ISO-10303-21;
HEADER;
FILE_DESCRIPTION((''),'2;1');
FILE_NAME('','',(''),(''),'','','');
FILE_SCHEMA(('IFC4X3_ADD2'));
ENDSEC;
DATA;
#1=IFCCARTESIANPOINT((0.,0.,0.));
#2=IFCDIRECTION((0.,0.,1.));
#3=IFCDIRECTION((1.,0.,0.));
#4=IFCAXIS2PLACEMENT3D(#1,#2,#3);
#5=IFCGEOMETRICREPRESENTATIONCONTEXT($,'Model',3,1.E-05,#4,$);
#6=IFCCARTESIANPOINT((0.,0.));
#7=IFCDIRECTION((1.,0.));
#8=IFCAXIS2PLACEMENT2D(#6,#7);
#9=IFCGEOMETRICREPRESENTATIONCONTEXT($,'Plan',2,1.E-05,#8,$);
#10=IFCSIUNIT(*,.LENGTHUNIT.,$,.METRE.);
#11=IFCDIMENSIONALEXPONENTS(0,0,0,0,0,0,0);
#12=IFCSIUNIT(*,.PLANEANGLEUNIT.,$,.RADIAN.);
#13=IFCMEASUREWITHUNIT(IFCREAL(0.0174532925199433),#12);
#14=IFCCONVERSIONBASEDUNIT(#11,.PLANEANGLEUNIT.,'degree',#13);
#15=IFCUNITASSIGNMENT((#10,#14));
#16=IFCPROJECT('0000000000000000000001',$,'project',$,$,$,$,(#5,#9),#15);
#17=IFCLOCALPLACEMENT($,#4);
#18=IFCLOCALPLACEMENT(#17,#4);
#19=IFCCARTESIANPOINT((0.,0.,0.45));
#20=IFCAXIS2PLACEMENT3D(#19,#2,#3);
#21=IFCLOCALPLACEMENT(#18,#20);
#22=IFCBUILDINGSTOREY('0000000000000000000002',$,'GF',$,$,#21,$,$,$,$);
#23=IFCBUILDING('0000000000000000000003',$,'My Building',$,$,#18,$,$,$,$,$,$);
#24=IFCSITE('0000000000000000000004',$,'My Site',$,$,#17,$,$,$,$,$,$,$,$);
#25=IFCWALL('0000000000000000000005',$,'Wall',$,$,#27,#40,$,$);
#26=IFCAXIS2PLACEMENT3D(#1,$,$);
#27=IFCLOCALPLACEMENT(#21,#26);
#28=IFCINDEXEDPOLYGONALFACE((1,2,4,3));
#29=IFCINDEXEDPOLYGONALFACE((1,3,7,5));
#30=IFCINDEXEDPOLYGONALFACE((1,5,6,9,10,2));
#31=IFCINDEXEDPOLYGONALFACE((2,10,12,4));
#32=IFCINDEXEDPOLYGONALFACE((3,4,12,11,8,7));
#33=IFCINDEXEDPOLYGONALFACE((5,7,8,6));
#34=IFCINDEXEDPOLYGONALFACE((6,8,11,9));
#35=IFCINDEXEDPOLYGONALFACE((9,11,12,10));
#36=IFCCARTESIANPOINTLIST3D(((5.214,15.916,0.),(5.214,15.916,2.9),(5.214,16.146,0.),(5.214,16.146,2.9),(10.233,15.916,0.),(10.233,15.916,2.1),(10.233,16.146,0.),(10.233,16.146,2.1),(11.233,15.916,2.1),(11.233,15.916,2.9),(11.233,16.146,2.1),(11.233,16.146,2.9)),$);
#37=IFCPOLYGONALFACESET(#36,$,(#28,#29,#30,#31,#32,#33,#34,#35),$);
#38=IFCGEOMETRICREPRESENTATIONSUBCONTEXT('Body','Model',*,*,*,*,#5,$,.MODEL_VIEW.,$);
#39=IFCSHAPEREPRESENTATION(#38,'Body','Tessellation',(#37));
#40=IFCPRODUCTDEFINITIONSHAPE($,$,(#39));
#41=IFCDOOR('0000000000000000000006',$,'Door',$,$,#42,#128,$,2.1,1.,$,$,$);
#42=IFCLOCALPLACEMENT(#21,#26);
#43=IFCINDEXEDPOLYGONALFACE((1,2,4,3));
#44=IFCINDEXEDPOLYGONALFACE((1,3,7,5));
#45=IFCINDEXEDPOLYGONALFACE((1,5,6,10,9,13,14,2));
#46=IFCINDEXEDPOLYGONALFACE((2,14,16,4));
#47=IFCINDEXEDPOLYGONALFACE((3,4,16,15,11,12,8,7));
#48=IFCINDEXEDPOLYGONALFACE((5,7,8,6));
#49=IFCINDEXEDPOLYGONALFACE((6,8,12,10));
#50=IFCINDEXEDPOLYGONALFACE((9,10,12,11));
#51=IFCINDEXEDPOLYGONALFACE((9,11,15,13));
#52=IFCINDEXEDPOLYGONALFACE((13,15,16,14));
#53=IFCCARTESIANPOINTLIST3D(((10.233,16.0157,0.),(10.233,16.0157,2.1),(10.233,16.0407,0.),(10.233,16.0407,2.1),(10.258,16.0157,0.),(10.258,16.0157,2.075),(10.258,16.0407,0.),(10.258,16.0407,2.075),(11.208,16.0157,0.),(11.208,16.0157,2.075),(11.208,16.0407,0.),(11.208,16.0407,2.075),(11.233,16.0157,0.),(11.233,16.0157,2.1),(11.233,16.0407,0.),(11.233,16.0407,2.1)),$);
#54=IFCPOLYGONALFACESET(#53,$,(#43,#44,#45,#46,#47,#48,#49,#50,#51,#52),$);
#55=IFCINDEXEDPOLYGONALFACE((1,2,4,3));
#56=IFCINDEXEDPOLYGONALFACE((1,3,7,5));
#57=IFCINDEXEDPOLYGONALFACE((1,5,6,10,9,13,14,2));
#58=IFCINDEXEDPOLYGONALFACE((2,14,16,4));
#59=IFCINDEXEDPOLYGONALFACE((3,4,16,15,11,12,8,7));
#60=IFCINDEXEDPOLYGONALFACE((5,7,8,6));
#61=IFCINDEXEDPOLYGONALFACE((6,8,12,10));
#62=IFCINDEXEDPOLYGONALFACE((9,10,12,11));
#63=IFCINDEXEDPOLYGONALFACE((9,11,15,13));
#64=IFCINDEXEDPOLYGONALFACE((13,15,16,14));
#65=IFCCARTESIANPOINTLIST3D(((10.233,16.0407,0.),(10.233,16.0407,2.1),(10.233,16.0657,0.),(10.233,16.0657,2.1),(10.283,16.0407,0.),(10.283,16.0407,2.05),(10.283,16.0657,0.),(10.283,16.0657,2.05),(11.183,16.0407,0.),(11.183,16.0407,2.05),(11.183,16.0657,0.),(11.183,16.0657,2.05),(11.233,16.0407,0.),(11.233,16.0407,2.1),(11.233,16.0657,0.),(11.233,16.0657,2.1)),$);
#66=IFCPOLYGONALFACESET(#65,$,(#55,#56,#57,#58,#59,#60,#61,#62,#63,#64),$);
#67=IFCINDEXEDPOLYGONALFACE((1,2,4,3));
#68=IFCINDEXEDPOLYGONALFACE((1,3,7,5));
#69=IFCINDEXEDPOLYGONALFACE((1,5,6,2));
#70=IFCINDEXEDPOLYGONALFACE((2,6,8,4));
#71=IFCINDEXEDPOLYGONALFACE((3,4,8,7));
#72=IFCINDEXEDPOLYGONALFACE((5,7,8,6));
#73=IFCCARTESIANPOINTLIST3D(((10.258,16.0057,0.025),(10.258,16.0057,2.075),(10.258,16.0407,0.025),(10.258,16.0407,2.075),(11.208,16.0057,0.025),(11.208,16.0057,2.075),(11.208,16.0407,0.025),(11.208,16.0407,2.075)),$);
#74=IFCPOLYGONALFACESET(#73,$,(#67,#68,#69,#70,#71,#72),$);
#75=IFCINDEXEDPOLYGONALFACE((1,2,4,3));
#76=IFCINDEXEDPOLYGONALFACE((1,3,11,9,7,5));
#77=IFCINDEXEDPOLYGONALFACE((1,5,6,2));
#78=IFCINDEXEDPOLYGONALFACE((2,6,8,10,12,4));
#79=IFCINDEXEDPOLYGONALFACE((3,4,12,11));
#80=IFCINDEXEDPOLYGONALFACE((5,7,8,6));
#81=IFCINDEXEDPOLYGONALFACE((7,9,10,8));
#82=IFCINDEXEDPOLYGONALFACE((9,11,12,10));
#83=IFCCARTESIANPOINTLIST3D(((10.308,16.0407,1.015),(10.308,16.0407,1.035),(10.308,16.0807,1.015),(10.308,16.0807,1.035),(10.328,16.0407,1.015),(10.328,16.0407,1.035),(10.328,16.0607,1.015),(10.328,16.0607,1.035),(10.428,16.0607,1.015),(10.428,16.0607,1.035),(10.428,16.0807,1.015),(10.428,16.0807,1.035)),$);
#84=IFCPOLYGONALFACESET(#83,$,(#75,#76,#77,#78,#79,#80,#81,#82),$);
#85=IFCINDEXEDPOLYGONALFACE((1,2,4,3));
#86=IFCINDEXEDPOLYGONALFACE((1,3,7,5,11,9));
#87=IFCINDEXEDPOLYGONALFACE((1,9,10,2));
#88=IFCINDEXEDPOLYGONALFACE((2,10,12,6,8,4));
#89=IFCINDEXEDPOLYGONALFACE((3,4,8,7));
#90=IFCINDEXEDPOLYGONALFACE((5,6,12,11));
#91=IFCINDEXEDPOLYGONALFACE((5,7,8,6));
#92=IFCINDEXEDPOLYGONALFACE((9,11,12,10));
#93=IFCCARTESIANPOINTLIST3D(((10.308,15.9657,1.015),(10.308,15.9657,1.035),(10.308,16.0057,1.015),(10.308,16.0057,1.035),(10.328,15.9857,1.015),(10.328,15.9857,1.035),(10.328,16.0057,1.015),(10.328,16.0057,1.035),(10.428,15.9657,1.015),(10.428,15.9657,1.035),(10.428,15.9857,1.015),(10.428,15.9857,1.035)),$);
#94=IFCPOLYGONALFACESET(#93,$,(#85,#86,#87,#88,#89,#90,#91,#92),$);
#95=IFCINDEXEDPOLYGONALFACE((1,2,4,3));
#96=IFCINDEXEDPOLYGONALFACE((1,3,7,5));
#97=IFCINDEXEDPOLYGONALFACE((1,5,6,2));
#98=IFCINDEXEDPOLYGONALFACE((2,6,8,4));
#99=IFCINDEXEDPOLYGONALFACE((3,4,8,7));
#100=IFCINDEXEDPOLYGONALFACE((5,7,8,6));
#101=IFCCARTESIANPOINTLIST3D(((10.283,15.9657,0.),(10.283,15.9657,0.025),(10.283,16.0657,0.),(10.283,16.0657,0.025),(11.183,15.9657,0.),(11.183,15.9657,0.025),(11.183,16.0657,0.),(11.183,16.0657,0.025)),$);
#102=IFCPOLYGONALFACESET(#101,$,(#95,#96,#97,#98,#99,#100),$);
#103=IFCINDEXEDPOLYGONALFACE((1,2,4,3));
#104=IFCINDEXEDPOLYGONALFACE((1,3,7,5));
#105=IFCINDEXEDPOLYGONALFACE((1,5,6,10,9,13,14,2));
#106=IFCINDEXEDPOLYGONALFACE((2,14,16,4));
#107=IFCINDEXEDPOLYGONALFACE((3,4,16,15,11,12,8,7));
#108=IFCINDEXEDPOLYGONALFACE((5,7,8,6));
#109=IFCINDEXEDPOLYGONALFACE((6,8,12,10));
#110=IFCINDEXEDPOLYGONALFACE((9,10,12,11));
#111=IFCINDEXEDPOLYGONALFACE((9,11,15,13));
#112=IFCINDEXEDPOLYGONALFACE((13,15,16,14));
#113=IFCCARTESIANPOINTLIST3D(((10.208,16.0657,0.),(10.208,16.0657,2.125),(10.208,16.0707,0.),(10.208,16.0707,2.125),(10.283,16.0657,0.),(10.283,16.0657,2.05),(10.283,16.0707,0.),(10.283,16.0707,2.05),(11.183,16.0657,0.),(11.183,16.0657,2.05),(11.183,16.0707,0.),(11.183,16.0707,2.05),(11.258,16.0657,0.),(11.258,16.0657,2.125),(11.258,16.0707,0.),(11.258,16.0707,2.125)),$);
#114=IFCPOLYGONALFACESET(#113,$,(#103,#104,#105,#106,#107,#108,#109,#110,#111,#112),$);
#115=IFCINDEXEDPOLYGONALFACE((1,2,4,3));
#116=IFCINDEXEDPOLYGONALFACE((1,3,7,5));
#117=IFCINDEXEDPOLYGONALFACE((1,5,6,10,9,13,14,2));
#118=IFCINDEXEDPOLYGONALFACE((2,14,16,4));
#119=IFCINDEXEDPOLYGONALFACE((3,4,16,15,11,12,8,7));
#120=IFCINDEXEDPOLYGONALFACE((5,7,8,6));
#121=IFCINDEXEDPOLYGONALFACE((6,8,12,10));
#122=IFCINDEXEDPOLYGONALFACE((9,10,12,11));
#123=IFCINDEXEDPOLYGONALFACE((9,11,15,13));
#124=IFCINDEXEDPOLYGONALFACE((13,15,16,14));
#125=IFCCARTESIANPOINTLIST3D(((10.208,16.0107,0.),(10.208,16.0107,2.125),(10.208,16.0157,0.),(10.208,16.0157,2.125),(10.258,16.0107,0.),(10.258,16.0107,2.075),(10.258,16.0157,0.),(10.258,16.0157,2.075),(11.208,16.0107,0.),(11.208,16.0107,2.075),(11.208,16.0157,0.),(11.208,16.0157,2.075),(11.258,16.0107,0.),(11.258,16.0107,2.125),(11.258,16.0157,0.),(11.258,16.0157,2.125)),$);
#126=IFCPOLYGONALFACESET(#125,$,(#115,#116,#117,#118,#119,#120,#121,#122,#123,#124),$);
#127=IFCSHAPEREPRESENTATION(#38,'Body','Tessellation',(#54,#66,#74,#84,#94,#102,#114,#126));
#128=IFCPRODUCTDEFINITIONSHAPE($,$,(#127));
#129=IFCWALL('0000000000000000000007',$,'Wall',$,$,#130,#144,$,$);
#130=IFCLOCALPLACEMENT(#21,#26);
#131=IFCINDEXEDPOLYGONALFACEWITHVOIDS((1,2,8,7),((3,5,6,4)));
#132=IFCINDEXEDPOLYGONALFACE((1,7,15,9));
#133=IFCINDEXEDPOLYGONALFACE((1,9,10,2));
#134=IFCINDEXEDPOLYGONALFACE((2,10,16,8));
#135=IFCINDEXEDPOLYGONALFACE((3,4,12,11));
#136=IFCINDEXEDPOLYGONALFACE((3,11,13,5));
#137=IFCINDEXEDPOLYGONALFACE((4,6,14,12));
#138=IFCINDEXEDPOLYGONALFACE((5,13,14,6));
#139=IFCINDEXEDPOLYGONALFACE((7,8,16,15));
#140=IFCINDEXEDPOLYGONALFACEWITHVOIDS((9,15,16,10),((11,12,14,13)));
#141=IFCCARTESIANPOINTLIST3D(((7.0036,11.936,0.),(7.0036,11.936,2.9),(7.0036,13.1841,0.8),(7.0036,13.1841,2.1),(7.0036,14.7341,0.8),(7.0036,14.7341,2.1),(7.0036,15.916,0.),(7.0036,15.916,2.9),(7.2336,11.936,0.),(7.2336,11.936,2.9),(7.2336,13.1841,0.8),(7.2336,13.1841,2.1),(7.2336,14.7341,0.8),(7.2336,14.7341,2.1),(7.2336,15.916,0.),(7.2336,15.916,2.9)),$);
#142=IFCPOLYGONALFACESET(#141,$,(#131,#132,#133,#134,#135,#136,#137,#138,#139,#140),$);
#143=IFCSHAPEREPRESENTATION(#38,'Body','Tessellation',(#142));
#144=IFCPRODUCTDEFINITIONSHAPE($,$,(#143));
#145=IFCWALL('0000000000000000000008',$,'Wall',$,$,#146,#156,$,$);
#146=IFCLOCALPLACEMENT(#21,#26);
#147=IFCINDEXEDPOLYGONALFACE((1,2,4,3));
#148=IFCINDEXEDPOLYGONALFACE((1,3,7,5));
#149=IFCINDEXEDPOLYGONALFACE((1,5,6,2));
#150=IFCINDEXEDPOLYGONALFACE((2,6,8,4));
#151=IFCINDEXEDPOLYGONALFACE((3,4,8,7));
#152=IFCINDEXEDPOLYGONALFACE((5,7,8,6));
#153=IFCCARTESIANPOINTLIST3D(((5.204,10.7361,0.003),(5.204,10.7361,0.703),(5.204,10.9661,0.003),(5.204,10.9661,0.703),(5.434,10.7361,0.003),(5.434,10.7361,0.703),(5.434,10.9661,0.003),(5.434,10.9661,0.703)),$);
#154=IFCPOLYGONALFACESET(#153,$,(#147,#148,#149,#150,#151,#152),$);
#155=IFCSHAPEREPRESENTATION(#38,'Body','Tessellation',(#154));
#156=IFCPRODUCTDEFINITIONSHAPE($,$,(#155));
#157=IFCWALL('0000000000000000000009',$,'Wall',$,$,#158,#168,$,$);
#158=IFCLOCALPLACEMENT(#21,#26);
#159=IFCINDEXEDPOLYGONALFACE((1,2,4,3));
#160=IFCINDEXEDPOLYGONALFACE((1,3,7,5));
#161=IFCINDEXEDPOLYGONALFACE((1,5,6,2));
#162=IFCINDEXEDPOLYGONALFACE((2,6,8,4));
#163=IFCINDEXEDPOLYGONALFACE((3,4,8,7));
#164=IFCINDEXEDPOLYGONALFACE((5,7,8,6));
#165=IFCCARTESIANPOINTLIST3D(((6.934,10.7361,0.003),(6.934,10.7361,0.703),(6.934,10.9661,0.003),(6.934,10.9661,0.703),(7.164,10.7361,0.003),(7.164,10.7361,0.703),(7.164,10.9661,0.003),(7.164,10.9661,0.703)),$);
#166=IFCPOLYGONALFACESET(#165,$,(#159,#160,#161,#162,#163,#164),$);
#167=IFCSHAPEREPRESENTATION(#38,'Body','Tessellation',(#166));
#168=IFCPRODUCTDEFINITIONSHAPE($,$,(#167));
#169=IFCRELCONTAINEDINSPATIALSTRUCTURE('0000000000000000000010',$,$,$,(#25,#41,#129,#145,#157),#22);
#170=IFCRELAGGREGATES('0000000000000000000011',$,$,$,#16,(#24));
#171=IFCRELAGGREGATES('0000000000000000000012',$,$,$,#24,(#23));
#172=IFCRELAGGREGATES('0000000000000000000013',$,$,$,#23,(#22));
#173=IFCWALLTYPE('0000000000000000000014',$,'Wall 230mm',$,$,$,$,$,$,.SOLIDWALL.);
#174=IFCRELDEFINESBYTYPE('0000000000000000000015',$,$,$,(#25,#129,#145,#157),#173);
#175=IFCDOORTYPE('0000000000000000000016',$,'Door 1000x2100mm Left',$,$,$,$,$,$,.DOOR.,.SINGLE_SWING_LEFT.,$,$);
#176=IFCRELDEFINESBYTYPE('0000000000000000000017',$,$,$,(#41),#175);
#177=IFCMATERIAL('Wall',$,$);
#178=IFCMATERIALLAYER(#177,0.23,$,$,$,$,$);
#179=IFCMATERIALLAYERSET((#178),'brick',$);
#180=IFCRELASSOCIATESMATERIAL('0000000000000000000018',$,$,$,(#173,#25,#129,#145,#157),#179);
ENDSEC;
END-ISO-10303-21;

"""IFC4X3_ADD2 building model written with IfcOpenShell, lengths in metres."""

from ifc_helpers import new_model, entity, si_unit, converted_unit, frame, origin_with_axes, origin_2d_with_axis, place, context, subcontext, project, spatial, line, indexed_curve, outline, extrude, shape, source, transform, mapped, material, layer, layer_set, layer_usage, type_object, type_shapes, element, fill, save


model = new_model("IFC4X3_ADD2")

# Units and contexts
model_context = context("Model", 3, precision=1e-05, world=origin_with_axes())
plan_context = context("Plan", 2, precision=1e-05, world=origin_2d_with_axis())
body_context_1 = subcontext(model_context, "Body", "Model", "MODEL_VIEW")
body_context_2 = subcontext(plan_context, "Body", "Plan", "PLAN_VIEW")
ifc_project = project(units=[si_unit("LENGTHUNIT", "METRE"), converted_unit("PLANEANGLEUNIT", "degree", entity("IfcReal", 0.0174532925199433), si_unit("PLANEANGLEUNIT", "RADIAN"), dimensions=[0, 0, 0, 0, 0, 0, 0])], contexts=[model_context, plan_context])

# Site, building, storey
site_placement = place(None, origin_with_axes())
site = spatial("IfcSite", under=ifc_project, at=site_placement, Name="My Site")
building_placement = place(site_placement, origin_with_axes())
building = spatial("IfcBuilding", under=site, at=building_placement, Name="My Building")
storey_placement = place(building_placement, frame((0.0, 0.0, 0.45), z_axis=(0.0, 0.0, 1.0), x_axis=(1.0, 0.0, 0.0)))
storey = spatial("IfcBuildingStorey", under=building, at=storey_placement, Name="GF")

# Shared definitions
ifc_material_1 = material(Name="Wall")
ifc_layer_1 = layer(ifc_material_1, 0.23)
ifc_layer_set_1 = layer_set([ifc_layer_1], Name="brick")
wall_type_1 = type_object("IfcWallType", Name="Wall 230mm", PredefinedType="SOLIDWALL", material=ifc_layer_set_1)
shared_shape_1 = source(origin_with_axes(), body_context_1, "Body", "SweptSolid", [
    extrude(outline(indexed_curve([(0.0, 0.0), (1.55, 0.0), (1.55, 1.3), (0.0, 1.3)], segments=[line(1, 2, 3, 4, 1)])), frame((-0.775, -0.6, 0.0), z_axis=(0.0, -1.0, 0.0), x_axis=(1.0, 0.0, 0.0)), (0.0, 0.0, -1.0), 1.2),
])

# Wall, opening, door
ifc_layer_usage_1 = layer_usage(ifc_layer_set_1, "AXIS2", "POSITIVE", 0.0)
wall_1_placement = place(storey_placement, frame((5.214, 15.916, 0.0), z_axis=(0.0, 0.0, 1.0), x_axis=(1.0, 0.0, 0.0)))
wall_1 = element("IfcWall", 1, at=wall_1_placement, inside=storey, type_object=wall_type_1, material=ifc_layer_usage_1, Name="Wall", context=body_context_1, shape_type="SweptSolid", body=[
    extrude(outline(indexed_curve([(0.0, 0.0), (0.0, 0.23), (6.019, 0.23), (6.019, 0.0), (0.0, 0.0)], self_intersect=False)), origin_with_axes(), (0.0, 0.0, 1.0), 2.9),
])
shared_shape_2 = source(origin_with_axes(), body_context_1, "Body", "SweptSolid", [
    extrude(outline(indexed_curve([(0.0, 0.0), (1.0, 0.0), (1.0, 2.1), (0.0, 2.1)], segments=[line(1, 2, 3, 4, 1)])), frame((0.0, -0.6, 0.0), z_axis=(0.0, -1.0, 0.0), x_axis=(1.0, 0.0, 0.0)), (0.0, 0.0, -1.0), 1.2),
])
opening_1_placement = place(wall_1_placement, frame((6.019, -0.317, 0.0), z_axis=(0.0, 0.0, 1.0), x_axis=(-1.0, 0.0, 0.0)))
opening_1 = element("IfcOpeningElement", 2, at=opening_1_placement, cuts=wall_1, PredefinedType="OPENING", context=body_context_1, shape_type="MappedRepresentation", body=[
    mapped(shared_shape_2, transform((0.0, 0.0, 0.0), x_axis=(1.0, 0.0, 0.0), y_axis=(0.0, 1.0, 0.0), z_axis=(0.0, 0.0, 1.0), scale=1.0)),
])
door_type = type_object("IfcDoorType", Name="Door 1000x2100mm Left", OperationType="SINGLE_SWING_LEFT", PredefinedType="DOOR")
shared_shape_3 = source(origin_with_axes(), body_context_1, "Body", "SweptSolid", [
    extrude(outline(indexed_curve([(0.0, 0.0), (0.0, 2.1), (1.0, 2.1), (1.0, 0.0), (0.975, 0.0), (0.975, 2.075), (0.025, 2.075), (0.025, 0.0)], segments=[line(1, 2, 3, 4, 5, 6, 7, 8, 1)])), frame((0.0, 0.025, 0.0), z_axis=(0.0, -1.0, 0.0), x_axis=(1.0, 0.0, 0.0)), (0.0, 0.0, -1.0), 0.025),
    extrude(outline(indexed_curve([(0.0, 0.0), (0.0, 2.1), (1.0, 2.1), (1.0, 0.0), (0.95, 0.0), (0.95, 2.05), (0.05, 2.05), (0.05, 0.0)], segments=[line(1, 2, 3, 4, 5, 6, 7, 8, 1)])), frame((0.0, 0.0, 0.0), z_axis=(0.0, -1.0, 0.0), x_axis=(1.0, 0.0, 0.0)), (0.0, 0.0, -1.0), 0.025),
    extrude(outline(indexed_curve([(0.0, 0.0), (0.95, 0.0), (0.95, 0.035), (0.0, 0.035)], segments=[line(1, 2, 3, 4, 1)])), frame((0.025, 0.025, 0.025), z_axis=(0.0, 0.0, 1.0), x_axis=(1.0, 0.0, 0.0)), (0.0, 0.0, 1.0), 2.05),
    extrude(outline(indexed_curve([(0.0, 0.0), (0.0, -0.04), (-0.12, -0.04), (-0.12, -0.02), (-0.02, -0.02), (-0.02, 0.0)], segments=[line(1, 2, 3, 4, 5, 6, 1)])), frame((0.925, 0.025, 1.015), z_axis=(0.0, 0.0, 1.0), x_axis=(1.0, 0.0, 0.0)), (0.0, 0.0, 1.0), 0.02),
    extrude(outline(indexed_curve([(0.0, 0.0), (0.0, 0.04), (-0.12, 0.04), (-0.12, 0.02), (-0.02, 0.02), (-0.02, 0.0)], segments=[line(1, 2, 3, 4, 5, 6, 1)])), frame((0.925, 0.06, 1.015), z_axis=(0.0, 0.0, 1.0), x_axis=(1.0, 0.0, 0.0)), (0.0, 0.0, 1.0), 0.02),
    extrude(outline(indexed_curve([(0.0, 0.0), (0.9, 0.0), (0.9, 0.1), (0.0, 0.1)], segments=[line(1, 2, 3, 4, 1)])), frame((0.05, 0.0, 0.0), z_axis=(0.0, 0.0, 1.0), x_axis=(1.0, 0.0, 0.0)), (0.0, 0.0, 1.0), 0.025),
    extrude(outline(indexed_curve([(0.0, 0.0), (0.0, 2.125), (1.05, 2.125), (1.05, 0.0), (0.975, 0.0), (0.975, 2.05), (0.075, 2.05), (0.075, 0.0)], segments=[line(1, 2, 3, 4, 5, 6, 7, 8, 1)])), frame((-0.025, -0.005, 0.0), z_axis=(0.0, -1.0, 0.0), x_axis=(1.0, 0.0, 0.0)), (0.0, 0.0, -1.0), 0.005),
    extrude(outline(indexed_curve([(0.0, 0.0), (0.0, 2.125), (1.05, 2.125), (1.05, 0.0), (1.0, 0.0), (1.0, 2.075), (0.05, 2.075), (0.05, 0.0)], segments=[line(1, 2, 3, 4, 5, 6, 7, 8, 1)])), frame((-0.025, 0.05, 0.0), z_axis=(0.0, -1.0, 0.0), x_axis=(1.0, 0.0, 0.0)), (0.0, 0.0, -1.0), 0.005),
])
shared_shape_4 = source(origin_with_axes(), body_context_2, "Body", "Curve2D", [
    entity("IfcIndexedPolyCurve", entity("IfcCartesianPointList2D", [[0.0, 0.0], [0.0, 0.05], [0.025, 0.05], [0.025, 0.025], [0.05, 0.025], [0.05, 0.0]]), [entity("IfcLineIndex", [1, 2, 3, 4, 5, 6, 1])]),
    entity("IfcIndexedPolyCurve", entity("IfcCartesianPointList2D", [[1.0, 0.0], [1.0, 0.05], [0.975, 0.05], [0.975, 0.025], [0.95, 0.025], [0.95, 0.0]]), [entity("IfcLineIndex", [1, 2, 3, 4, 5, 6, 1])]),
    entity("IfcTrimmedCurve", entity("IfcEllipse", entity("IfcAxis2Placement2D", entity("IfcCartesianPoint", [0.06, 0.05]), entity("IfcDirection", [1.0, 0.0])), 0.915, 0.95), [entity("IfcCartesianPoint", [0.975, 0.05])], [entity("IfcCartesianPoint", [0.06, 1.0])], True, "CARTESIAN"),
    entity("IfcIndexedPolyCurve", entity("IfcCartesianPointList2D", [[0.025, 0.05], [0.06, 0.05], [0.06, 1.0], [0.025, 1.0]]), [entity("IfcLineIndex", [1, 2, 3, 4, 1])]),
])
type_shapes(door_type, [shared_shape_3, shared_shape_4])
door_placement = place(opening_1_placement, frame((0.0, -0.4667, 0.0), z_axis=(0.0, 0.0, 1.0), x_axis=(1.0, 0.0, 0.0)))
door = element("IfcDoor", 3, at=door_placement, inside=storey, type_object=door_type, Name="Door", OverallHeight=2.1, OverallWidth=1.0, shapes=[
    shape(body_context_1, "Body", "MappedRepresentation", [mapped(shared_shape_3, transform((0.0, 0.0, 0.0), x_axis=(1.0, 0.0, 0.0), y_axis=(0.0, 1.0, 0.0), z_axis=(0.0, 0.0, 1.0), scale=1.0))]),
    shape(body_context_2, "Body", "MappedRepresentation", [mapped(shared_shape_4, transform((0.0, 0.0, 0.0), x_axis=(1.0, 0.0, 0.0), y_axis=(0.0, 1.0, 0.0), z_axis=(0.0, 0.0, 1.0), scale=1.0))]),
])
fill(opening_1, door)

# Wall, opening
ifc_layer_usage_2 = layer_usage(ifc_layer_set_1, "AXIS2", "POSITIVE", 0.0)
wall_2_placement = place(storey_placement, frame((7.2336, 11.936, 0.0), z_axis=(0.0, 0.0, 1.0), x_axis=(0.0, 1.0, 0.0)))
wall_2 = element("IfcWall", 4, at=wall_2_placement, inside=storey, type_object=wall_type_1, material=ifc_layer_usage_2, Name="Wall", context=body_context_1, shape_type="SweptSolid", body=[
    extrude(outline(indexed_curve([(0.0, 0.0), (0.0, 0.23), (3.98, 0.23), (3.98, 0.0), (0.0, 0.0)], self_intersect=False)), origin_with_axes(), (0.0, 0.0, 1.0), 2.9),
])
opening_2_placement = place(wall_2_placement, frame((2.0231, -0.0082, 0.8), z_axis=(0.0, 0.0, 1.0), x_axis=(1.0, 0.0, 0.0)))
element("IfcOpeningElement", 5, at=opening_2_placement, cuts=wall_2, PredefinedType="OPENING", context=body_context_1, shape_type="MappedRepresentation", body=[
    mapped(shared_shape_1, transform((0.0, 0.0, 0.0), x_axis=(1.0, 0.0, 0.0), y_axis=(0.0, 1.0, 0.0), z_axis=(0.0, 0.0, 1.0), scale=1.0)),
])

# Walls
ifc_layer_usage_3 = layer_usage(ifc_layer_set_1, "AXIS2", "POSITIVE", 0.0)
wall_3_placement = place(storey_placement, frame((5.204, 10.7361, 0.003), z_axis=(0.0, 0.0, 1.0), x_axis=(1.0, -0.000001, 0.0)))
element("IfcWall", 6, at=wall_3_placement, inside=storey, type_object=wall_type_1, material=ifc_layer_usage_3, Name="Wall", context=body_context_1, shape_type="SweptSolid", body=[
    extrude(outline(indexed_curve([(0.0, 0.0), (0.0, 0.23), (0.23, 0.23), (0.23, 0.0), (0.0, 0.0)], self_intersect=False)), origin_with_axes(), (0.0, 0.0, 1.0), 0.7),
])
ifc_layer_usage_4 = layer_usage(ifc_layer_set_1, "AXIS2", "POSITIVE", 0.0)
wall_4_placement = place(storey_placement, frame((6.934, 10.7361, 0.003), z_axis=(0.0, 0.0, 1.0), x_axis=(1.0, -0.000001, 0.0)))
element("IfcWall", 7, at=wall_4_placement, inside=storey, type_object=wall_type_1, material=ifc_layer_usage_4, Name="Wall", context=body_context_1, shape_type="SweptSolid", body=[
    extrude(outline(indexed_curve([(0.0, 0.0), (0.0, 0.23), (0.23, 0.23), (0.23, 0.0), (0.0, 0.0)], self_intersect=False)), origin_with_axes(), (0.0, 0.0, 1.0), 0.7),
])

save(model, "model.ifc")
